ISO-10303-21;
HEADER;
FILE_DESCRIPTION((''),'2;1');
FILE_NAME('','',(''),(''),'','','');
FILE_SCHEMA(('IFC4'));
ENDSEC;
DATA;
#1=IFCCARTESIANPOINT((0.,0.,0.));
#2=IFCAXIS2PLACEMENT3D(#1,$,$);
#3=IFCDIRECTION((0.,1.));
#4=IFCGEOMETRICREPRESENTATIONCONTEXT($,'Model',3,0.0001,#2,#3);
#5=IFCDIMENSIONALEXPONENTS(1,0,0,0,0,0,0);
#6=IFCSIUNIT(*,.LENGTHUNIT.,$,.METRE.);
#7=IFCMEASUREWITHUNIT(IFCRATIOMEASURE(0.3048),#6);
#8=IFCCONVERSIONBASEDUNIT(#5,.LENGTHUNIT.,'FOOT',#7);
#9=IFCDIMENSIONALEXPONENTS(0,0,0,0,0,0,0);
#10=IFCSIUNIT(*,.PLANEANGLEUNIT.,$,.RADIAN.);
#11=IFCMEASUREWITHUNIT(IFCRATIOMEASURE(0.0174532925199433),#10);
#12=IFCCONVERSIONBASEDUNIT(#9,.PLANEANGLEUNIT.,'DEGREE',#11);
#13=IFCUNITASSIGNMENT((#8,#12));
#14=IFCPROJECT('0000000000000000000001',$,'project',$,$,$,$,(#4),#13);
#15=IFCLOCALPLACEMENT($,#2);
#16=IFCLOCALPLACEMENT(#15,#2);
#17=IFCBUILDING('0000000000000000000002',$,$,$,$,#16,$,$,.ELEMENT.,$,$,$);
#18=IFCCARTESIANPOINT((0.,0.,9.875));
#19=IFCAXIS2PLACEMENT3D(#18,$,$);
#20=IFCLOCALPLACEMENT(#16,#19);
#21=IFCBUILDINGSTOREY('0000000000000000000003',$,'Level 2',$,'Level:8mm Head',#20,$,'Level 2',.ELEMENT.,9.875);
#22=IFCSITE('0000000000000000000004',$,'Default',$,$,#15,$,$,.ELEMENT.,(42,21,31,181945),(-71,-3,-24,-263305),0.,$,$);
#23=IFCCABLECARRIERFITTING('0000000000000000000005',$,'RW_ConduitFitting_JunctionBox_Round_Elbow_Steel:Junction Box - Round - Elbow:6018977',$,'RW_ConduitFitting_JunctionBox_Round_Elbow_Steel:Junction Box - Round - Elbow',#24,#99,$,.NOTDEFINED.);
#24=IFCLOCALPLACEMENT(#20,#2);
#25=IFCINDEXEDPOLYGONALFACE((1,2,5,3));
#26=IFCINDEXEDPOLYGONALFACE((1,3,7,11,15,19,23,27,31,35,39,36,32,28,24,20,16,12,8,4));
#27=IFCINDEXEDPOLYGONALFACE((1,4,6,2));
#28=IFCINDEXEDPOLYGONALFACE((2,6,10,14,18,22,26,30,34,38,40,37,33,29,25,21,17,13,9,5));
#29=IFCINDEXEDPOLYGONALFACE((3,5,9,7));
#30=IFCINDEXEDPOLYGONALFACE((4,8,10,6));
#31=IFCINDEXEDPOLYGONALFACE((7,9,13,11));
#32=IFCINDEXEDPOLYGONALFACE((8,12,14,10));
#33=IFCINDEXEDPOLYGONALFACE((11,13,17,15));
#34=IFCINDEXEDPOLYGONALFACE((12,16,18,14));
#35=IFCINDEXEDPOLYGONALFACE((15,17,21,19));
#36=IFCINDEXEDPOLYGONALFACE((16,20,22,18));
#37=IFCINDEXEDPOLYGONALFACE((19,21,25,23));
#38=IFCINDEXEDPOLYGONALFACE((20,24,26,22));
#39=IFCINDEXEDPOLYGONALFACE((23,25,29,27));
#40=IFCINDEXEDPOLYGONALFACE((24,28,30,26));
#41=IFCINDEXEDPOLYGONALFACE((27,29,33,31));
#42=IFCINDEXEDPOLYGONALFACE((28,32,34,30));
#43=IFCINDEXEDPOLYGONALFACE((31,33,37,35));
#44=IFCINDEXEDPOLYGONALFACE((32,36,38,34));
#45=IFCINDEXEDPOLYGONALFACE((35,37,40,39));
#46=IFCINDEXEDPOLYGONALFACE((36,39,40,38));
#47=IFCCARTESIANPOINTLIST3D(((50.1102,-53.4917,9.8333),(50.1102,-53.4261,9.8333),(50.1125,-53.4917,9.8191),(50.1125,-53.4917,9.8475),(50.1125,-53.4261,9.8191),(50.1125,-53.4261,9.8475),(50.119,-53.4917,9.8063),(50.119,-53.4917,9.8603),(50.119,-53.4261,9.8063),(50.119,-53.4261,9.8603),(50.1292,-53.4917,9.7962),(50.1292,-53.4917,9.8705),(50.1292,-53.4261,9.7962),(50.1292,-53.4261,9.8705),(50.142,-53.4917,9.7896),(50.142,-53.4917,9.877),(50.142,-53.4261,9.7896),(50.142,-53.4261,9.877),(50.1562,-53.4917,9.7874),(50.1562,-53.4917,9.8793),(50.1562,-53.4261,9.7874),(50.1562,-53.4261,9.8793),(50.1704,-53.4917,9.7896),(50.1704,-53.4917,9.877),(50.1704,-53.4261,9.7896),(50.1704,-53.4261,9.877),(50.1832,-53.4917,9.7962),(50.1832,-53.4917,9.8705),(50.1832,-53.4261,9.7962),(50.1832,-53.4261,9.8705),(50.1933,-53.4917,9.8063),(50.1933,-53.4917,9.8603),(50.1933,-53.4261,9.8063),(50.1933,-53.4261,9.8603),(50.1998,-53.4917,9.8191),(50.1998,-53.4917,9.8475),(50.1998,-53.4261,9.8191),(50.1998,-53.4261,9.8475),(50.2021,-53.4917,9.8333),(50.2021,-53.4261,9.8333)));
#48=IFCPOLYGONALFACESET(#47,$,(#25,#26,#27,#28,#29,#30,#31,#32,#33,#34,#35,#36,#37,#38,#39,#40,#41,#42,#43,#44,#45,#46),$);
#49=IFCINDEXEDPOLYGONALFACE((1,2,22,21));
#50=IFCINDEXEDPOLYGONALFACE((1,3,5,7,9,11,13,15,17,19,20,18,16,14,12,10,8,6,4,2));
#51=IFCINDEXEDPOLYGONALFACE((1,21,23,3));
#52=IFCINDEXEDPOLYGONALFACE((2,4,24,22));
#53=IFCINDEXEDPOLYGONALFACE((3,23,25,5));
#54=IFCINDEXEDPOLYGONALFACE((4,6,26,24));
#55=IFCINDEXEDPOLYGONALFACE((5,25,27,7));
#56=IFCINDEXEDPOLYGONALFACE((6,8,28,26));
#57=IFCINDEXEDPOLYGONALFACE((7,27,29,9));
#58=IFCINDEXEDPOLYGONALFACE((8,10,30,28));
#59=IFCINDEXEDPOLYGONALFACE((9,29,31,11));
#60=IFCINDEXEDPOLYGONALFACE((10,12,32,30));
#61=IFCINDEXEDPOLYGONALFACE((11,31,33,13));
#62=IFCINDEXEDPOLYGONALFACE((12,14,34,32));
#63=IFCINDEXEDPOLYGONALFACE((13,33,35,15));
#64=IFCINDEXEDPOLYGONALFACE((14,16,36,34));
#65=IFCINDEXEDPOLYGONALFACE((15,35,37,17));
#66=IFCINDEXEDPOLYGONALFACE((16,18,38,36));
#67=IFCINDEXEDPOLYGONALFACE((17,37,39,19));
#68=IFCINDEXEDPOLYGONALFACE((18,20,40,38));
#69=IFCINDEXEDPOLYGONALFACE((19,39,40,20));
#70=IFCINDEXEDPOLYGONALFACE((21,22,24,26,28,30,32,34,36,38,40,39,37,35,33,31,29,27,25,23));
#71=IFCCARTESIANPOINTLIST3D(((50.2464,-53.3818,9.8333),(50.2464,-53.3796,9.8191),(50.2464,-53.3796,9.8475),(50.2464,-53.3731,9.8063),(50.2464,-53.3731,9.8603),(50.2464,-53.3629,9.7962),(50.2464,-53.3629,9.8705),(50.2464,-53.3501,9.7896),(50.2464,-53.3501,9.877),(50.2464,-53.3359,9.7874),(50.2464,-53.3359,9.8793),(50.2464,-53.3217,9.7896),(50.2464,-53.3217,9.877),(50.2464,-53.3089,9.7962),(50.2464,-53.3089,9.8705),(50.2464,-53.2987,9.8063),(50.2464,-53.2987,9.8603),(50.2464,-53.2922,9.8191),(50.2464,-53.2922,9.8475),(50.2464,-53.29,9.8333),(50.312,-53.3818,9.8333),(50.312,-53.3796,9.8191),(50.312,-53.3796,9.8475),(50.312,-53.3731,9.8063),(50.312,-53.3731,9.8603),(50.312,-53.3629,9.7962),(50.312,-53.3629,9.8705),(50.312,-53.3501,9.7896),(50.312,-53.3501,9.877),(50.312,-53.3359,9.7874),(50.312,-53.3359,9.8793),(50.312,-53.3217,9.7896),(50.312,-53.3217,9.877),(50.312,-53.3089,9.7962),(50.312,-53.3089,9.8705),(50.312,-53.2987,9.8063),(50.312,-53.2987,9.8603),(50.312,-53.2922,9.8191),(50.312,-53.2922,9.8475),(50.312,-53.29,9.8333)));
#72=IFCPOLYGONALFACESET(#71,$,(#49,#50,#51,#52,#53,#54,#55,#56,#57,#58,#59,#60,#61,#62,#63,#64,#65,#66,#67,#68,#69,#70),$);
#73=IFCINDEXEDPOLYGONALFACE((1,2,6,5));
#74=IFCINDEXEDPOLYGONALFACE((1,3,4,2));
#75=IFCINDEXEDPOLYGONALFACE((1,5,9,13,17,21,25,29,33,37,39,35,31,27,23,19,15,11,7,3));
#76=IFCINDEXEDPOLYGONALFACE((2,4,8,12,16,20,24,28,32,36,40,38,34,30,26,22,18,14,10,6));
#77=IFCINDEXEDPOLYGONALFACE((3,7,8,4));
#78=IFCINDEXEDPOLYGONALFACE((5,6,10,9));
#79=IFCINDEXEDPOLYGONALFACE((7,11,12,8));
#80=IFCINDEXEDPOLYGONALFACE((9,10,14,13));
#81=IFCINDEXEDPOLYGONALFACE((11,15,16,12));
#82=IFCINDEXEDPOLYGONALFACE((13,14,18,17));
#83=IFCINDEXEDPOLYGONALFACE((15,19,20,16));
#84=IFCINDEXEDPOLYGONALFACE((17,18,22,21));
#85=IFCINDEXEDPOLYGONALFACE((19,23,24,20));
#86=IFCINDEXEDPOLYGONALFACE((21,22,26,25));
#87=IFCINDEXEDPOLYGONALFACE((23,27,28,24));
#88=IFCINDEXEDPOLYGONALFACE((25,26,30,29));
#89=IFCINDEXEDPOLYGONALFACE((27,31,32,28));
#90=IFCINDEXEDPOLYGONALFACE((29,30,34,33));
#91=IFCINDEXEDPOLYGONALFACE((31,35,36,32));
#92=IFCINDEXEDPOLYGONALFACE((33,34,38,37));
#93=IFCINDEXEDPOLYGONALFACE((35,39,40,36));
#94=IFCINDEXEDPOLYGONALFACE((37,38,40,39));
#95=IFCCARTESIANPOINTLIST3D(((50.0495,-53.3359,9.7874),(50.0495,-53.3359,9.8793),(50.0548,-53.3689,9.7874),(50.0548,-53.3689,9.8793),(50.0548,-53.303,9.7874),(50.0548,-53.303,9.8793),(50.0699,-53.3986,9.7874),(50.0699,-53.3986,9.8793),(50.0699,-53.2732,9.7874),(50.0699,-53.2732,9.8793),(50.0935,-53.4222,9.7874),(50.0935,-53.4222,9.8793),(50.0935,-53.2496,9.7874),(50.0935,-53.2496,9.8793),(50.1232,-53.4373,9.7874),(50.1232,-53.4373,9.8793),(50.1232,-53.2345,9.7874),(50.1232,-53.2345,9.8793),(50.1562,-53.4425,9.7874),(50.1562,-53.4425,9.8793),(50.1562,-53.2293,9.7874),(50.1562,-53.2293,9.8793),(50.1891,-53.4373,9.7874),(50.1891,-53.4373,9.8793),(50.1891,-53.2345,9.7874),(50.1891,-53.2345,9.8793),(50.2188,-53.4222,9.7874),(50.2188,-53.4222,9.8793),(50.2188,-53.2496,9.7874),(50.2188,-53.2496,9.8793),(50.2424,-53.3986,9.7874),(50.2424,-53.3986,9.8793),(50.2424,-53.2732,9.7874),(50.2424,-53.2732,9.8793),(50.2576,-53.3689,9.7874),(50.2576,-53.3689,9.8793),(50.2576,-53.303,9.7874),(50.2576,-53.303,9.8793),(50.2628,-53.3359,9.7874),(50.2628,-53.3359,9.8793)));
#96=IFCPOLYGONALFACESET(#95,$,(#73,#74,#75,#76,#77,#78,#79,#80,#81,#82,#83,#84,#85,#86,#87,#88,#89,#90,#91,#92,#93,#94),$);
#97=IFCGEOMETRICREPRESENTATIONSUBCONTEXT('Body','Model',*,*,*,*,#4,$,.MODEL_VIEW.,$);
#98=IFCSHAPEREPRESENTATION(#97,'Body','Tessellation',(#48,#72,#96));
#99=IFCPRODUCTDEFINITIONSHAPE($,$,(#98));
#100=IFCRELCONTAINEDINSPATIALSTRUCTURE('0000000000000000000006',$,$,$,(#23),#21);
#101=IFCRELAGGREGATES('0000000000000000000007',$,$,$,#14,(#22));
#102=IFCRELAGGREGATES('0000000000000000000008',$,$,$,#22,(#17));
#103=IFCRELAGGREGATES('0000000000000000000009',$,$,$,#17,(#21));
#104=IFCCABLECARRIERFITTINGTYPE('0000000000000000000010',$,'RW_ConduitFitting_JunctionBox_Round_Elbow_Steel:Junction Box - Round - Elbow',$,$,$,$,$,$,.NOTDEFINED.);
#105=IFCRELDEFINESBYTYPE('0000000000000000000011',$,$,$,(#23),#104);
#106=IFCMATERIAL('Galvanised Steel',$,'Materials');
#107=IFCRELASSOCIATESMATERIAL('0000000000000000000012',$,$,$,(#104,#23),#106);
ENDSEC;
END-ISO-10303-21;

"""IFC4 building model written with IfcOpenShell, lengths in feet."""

from ifc_helpers import new_model, entity, si_unit, converted_unit, direction, frame, origin, place, context, subcontext, project, spatial, indexed_curve, outline, extrude, source, transform, mapped, material, type_object, type_shapes, element, save


model = new_model("IFC4")

# Units and contexts
model_context = context("Model", 3, precision=0.0001, world=origin(), true_north=direction((0.0, 1.0)))
body_context = subcontext(model_context, "Body", "Model", "MODEL_VIEW")
ifc_project = project(units=[converted_unit("LENGTHUNIT", "FOOT", entity("IfcRatioMeasure", 0.3048), si_unit("LENGTHUNIT", "METRE"), dimensions=[1, 0, 0, 0, 0, 0, 0]), converted_unit("PLANEANGLEUNIT", "DEGREE", entity("IfcRatioMeasure", 0.0174532925199433), si_unit("PLANEANGLEUNIT", "RADIAN"), dimensions=[0, 0, 0, 0, 0, 0, 0])], contexts=[model_context])

# Site, building, storey
site_placement = place(None, origin())
site = spatial("IfcSite", under=ifc_project, at=site_placement, Name="Default", CompositionType="ELEMENT", RefLatitude=(42, 21, 31, 181945), RefLongitude=(-71, -3, -24, -263305), RefElevation=0.0)
building_placement = place(site_placement, origin())
building = spatial("IfcBuilding", under=site, at=building_placement, CompositionType="ELEMENT")
storey_placement = place(building_placement, frame((0.0, 0.0, 9.875)))
storey = spatial("IfcBuildingStorey", under=building, at=storey_placement, Name="Level 2", ObjectType="Level:8mm Head", LongName="Level 2", CompositionType="ELEMENT", Elevation=9.875)

# Cable carrier fitting
ifc_material_1 = material(Name="Galvanised Steel", Category="Materials")
cable_carrier_fitting_type_1 = type_object("IfcCableCarrierFittingType", Name="RW_ConduitFitting_JunctionBox_Round_Elbow_Steel:Junction Box - Round - Elbow", PredefinedType="NOTDEFINED", material=ifc_material_1)
shared_shape_1 = source(origin(), body_context, "Body", "SweptSolid", [
    extrude(outline(indexed_curve([(0.0459, 0.0), (0.0437, 0.0142), (0.0372, 0.027), (0.027, 0.0372), (0.0142, 0.0437), (0.0, 0.0459), (-0.0142, 0.0437), (-0.027, 0.0372), (-0.0372, 0.027), (-0.0437, 0.0142), (-0.0459, 0.0), (-0.0437, -0.0142), (-0.0372, -0.027), (-0.027, -0.0372), (-0.0142, -0.0437), (0.0, -0.0459), (0.0142, -0.0437), (0.027, -0.0372), (0.0372, -0.027), (0.0437, -0.0142), (0.0459, 0.0)], self_intersect=False)), frame((0.0, 0.0902, 0.0), z_axis=(0.0, 1.0, 0.0), x_axis=(-1.0, 0.0, 0.0)), (0.0, 0.0, 1.0), 0.0656),
    extrude(outline(indexed_curve([(0.0459, 0.0), (0.0437, 0.0142), (0.0372, 0.027), (0.027, 0.0372), (0.0142, 0.0437), (0.0, 0.0459), (-0.0142, 0.0437), (-0.027, 0.0372), (-0.0372, 0.027), (-0.0437, 0.0142), (-0.0459, 0.0), (-0.0437, -0.0142), (-0.0372, -0.027), (-0.027, -0.0372), (-0.0142, -0.0437), (0.0, -0.0459), (0.0142, -0.0437), (0.027, -0.0372), (0.0372, -0.027), (0.0437, -0.0142), (0.0459, 0.0)], self_intersect=False)), frame((-0.1558, 0.0, 0.0), z_axis=(1.0, 0.0, 0.0), x_axis=(0.0, 1.0, 0.0)), (0.0, 0.0, 1.0), 0.0656),
    extrude(outline(indexed_curve([(0.1066, 0.0), (0.1014, 0.0329), (0.0863, 0.0627), (0.0627, 0.0863), (0.0329, 0.1014), (0.0, 0.1066), (-0.0329, 0.1014), (-0.0627, 0.0863), (-0.0863, 0.0627), (-0.1014, 0.0329), (-0.1066, 0.0), (-0.1014, -0.0329), (-0.0863, -0.0627), (-0.0627, -0.0863), (-0.0329, -0.1014), (0.0, -0.1066), (0.0329, -0.1014), (0.0627, -0.0863), (0.0863, -0.0627), (0.1014, -0.0329), (0.1066, 0.0)], self_intersect=False)), frame((0.0, 0.0, -0.0459)), (0.0, 0.0, 1.0), 0.0919),
])
type_shapes(cable_carrier_fitting_type_1, [shared_shape_1])
cable_carrier_fitting_1_placement = place(storey_placement, frame((50.1562, -53.3359, 9.8333), z_axis=(0.0, 0.0, 1.0), x_axis=(-1.0, 0.0, 0.0)))
element("IfcCableCarrierFitting", 1, at=cable_carrier_fitting_1_placement, inside=storey, type_object=cable_carrier_fitting_type_1, material=ifc_material_1, Name="RW_ConduitFitting_JunctionBox_Round_Elbow_Steel:Junction Box - Round - Elbow:6018977", ObjectType="RW_ConduitFitting_JunctionBox_Round_Elbow_Steel:Junction Box - Round - Elbow", PredefinedType="NOTDEFINED", context=body_context, shape_type="MappedRepresentation", body=[
    mapped(shared_shape_1, transform((0.0, 0.0, 0.0), scale=1.0)),
])

save(model, "model.ifc")
